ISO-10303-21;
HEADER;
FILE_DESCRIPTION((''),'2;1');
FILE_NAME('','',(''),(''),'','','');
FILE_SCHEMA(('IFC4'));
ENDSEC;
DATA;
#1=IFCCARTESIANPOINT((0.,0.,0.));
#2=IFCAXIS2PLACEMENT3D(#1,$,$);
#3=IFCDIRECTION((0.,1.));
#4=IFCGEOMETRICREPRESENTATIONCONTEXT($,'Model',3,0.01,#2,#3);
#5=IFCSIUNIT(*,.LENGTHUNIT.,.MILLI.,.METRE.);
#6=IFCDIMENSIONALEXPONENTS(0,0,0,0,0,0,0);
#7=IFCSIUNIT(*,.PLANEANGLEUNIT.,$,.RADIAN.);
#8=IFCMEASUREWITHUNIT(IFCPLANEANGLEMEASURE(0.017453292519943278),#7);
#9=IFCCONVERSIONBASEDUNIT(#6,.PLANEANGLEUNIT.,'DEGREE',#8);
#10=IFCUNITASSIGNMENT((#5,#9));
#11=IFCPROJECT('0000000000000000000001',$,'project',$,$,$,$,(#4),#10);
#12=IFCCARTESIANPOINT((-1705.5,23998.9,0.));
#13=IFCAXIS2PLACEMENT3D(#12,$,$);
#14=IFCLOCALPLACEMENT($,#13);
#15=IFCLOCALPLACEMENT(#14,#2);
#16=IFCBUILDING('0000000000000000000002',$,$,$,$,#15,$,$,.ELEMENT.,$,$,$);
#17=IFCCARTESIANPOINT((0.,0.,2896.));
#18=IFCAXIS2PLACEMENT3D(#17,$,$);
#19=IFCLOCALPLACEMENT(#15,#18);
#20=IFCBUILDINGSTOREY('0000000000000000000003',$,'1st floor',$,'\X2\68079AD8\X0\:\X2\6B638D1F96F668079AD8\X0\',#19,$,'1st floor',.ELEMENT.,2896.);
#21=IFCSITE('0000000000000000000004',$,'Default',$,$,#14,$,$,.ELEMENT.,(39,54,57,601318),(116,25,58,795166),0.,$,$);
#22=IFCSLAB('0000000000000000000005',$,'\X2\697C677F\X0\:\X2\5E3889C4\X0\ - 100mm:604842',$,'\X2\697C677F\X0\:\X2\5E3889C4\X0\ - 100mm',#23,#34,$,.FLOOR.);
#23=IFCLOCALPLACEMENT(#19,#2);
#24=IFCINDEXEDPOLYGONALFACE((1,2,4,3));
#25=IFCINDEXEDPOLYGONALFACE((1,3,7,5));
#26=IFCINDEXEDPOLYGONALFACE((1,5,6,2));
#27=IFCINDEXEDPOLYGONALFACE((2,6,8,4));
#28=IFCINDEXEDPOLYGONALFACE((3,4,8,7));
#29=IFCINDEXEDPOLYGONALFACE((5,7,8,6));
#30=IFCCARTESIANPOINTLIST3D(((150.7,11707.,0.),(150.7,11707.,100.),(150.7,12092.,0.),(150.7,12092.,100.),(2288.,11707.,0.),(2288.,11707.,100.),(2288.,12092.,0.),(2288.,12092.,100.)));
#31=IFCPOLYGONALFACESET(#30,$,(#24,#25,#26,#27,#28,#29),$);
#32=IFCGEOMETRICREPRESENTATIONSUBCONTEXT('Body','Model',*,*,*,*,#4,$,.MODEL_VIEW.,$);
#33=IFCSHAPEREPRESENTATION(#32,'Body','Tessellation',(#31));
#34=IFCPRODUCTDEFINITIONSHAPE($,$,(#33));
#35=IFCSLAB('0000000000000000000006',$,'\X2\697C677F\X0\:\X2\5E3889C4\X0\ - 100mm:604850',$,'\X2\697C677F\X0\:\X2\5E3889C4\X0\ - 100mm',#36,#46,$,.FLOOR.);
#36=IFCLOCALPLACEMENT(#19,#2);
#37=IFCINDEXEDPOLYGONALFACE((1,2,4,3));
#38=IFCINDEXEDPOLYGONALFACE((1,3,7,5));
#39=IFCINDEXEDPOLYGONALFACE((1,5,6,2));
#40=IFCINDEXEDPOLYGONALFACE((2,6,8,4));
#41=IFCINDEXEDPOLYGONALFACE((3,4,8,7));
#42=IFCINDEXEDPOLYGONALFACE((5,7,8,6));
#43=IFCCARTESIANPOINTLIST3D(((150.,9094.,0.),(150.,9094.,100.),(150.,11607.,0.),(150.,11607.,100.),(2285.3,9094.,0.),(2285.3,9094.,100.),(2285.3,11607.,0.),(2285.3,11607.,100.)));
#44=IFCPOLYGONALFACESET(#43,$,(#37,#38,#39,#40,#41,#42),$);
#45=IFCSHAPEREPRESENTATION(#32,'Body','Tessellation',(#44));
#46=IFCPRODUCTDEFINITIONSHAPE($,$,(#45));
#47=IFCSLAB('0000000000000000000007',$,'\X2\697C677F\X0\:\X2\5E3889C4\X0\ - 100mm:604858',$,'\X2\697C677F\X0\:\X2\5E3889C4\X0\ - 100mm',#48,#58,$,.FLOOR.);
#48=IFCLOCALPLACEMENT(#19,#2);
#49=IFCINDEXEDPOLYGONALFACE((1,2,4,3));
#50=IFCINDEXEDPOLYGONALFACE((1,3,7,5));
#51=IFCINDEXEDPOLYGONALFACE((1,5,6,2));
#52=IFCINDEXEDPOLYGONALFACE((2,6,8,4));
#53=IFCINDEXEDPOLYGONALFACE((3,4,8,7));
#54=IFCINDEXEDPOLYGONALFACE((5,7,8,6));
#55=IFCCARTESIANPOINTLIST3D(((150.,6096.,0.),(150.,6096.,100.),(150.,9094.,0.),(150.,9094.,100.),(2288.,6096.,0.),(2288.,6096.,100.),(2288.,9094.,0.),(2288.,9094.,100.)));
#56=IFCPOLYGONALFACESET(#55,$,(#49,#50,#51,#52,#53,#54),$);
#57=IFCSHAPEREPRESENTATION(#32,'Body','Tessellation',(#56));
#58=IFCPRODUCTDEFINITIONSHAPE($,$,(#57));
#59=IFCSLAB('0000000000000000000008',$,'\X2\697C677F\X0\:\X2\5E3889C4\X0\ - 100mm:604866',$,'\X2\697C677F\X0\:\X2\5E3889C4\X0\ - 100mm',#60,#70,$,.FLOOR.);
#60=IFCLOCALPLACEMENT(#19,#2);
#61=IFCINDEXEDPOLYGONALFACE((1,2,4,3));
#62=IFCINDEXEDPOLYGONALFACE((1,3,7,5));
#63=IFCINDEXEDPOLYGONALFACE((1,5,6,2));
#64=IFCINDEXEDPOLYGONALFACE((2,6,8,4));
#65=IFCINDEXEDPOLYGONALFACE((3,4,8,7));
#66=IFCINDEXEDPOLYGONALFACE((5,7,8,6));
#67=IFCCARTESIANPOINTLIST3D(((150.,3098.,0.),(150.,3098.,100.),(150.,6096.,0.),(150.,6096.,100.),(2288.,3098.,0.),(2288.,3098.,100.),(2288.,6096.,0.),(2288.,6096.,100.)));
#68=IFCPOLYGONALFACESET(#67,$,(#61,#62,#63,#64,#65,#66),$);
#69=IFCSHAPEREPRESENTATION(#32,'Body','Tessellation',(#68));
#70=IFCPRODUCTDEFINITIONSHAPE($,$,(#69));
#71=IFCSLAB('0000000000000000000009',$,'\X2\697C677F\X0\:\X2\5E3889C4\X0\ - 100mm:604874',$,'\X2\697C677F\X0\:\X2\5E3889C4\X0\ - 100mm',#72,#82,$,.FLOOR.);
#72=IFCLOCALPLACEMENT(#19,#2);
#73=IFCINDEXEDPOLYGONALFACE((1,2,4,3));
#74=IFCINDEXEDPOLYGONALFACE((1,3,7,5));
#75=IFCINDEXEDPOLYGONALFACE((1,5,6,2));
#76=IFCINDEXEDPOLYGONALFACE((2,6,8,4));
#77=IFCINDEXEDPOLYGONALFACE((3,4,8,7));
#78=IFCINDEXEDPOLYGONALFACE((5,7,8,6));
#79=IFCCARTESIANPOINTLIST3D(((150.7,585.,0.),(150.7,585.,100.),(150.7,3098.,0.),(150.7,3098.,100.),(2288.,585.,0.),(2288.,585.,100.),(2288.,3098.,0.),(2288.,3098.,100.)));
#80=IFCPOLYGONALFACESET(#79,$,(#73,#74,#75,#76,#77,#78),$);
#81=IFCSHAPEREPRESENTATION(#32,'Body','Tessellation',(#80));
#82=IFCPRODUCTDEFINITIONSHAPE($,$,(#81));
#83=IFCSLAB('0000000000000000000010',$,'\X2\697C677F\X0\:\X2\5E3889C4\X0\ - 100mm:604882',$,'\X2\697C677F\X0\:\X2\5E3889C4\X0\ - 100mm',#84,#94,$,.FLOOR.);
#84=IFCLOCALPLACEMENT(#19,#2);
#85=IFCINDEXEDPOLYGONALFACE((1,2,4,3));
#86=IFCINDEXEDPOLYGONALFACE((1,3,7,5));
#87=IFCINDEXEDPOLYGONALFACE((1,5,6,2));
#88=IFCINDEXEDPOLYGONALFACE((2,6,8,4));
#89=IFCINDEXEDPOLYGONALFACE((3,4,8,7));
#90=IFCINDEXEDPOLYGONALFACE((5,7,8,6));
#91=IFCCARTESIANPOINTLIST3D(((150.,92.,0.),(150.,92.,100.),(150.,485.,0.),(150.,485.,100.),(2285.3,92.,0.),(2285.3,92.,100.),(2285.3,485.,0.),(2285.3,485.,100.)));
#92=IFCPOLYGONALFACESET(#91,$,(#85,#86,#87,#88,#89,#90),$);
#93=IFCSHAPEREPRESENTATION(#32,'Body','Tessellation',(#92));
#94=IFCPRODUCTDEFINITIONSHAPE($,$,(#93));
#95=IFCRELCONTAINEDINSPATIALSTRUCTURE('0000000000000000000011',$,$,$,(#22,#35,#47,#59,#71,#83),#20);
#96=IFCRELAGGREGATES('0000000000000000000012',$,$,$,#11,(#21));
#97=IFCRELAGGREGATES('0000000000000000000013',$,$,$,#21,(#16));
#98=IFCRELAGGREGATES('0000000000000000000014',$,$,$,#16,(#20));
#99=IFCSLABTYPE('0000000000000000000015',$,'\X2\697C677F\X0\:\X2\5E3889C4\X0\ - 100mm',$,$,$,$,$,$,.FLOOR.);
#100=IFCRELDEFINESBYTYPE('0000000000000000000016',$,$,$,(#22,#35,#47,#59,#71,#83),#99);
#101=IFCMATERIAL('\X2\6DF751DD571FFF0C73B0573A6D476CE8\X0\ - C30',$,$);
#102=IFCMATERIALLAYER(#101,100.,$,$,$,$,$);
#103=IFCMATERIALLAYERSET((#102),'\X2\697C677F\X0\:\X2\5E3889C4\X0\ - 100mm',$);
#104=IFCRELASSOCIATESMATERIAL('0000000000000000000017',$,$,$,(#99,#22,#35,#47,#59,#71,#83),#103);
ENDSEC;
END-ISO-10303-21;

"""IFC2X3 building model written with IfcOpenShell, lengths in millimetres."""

from ifc_helpers import new_model, entity, si_unit, converted_unit, direction, frame, frame_2d, origin, origin_2d_with_axis, place, context, subcontext, project, spatial, rectangle, extrude, material, layer, layer_set, layer_usage, type_object, element, save


model = new_model("IFC2X3")

# Units and contexts
model_context = context("Model", 3, precision=0.01, world=origin(), true_north=direction((0.0, 1.0)))
body_context = subcontext(model_context, "Body", "Model", "MODEL_VIEW")
ifc_project = project(units=[si_unit("LENGTHUNIT", "METRE", prefix="MILLI"), converted_unit("PLANEANGLEUNIT", "DEGREE", entity("IfcPlaneAngleMeasure", 0.017453292519943278), si_unit("PLANEANGLEUNIT", "RADIAN"), dimensions=[0, 0, 0, 0, 0, 0, 0])], contexts=[model_context])

# Site, building, storey
site_placement = place(None, frame((-1705.5, 23998.9, 0.0)))
site = spatial("IfcSite", under=ifc_project, at=site_placement, Name="Default", CompositionType="ELEMENT", RefLatitude=(39, 54, 57, 601318), RefLongitude=(116, 25, 58, 795166), RefElevation=0.0)
building_placement = place(site_placement, origin())
building = spatial("IfcBuilding", under=site, at=building_placement, CompositionType="ELEMENT")
storey_placement = place(building_placement, frame((0.0, 0.0, 2896.0)))
storey = spatial("IfcBuildingStorey", under=building, at=storey_placement, Name="1st floor", ObjectType="标高:正负零标高", LongName="1st floor", CompositionType="ELEMENT", Elevation=2896.0)

# Slabs
ifc_material_1 = material(Name="混凝土，现场浇注 - C30")
ifc_layer_1 = layer(ifc_material_1, 100.0)
ifc_layer_set_1 = layer_set([ifc_layer_1], Name="楼板:常规 - 100mm")
ifc_layer_usage_1 = layer_usage(ifc_layer_set_1, "AXIS3", "POSITIVE", 0.0)
slab_type = type_object("IfcSlabType", Name="楼板:常规 - 100mm", PredefinedType="FLOOR", material=ifc_layer_set_1)
slab_1_placement = place(storey_placement, origin())
element("IfcSlab", 1, at=slab_1_placement, inside=storey, type_object=slab_type, material=ifc_layer_usage_1, Name="楼板:常规 - 100mm:604842", ObjectType="楼板:常规 - 100mm", PredefinedType="FLOOR", context=body_context, shape_type="SweptSolid", body=[
    extrude(rectangle(XDim=385.0, YDim=2137.3, at=origin_2d_with_axis()), frame((1219.3, 11899.5, 100.0), z_axis=(0.0, 0.0, -1.0), x_axis=(0.0, 1.0, 0.0)), (0.0, 0.0, 1.0), 100.0),
])
ifc_layer_usage_2 = layer_usage(ifc_layer_set_1, "AXIS3", "POSITIVE", 0.0)
slab_2_placement = place(storey_placement, origin())
element("IfcSlab", 2, at=slab_2_placement, inside=storey, type_object=slab_type, material=ifc_layer_usage_2, Name="楼板:常规 - 100mm:604850", ObjectType="楼板:常规 - 100mm", PredefinedType="FLOOR", context=body_context, shape_type="SweptSolid", body=[
    extrude(rectangle(XDim=2513.0, YDim=2135.3, at=frame_2d((0.0, 0.0), x_axis=(1.0, 0.0))), frame((1217.6, 10350.5, 100.0), z_axis=(0.0, 0.0, -1.0), x_axis=(0.0, 1.0, 0.0)), (0.0, 0.0, 1.0), 100.0),
])
ifc_layer_usage_3 = layer_usage(ifc_layer_set_1, "AXIS3", "POSITIVE", 0.0)
slab_3_placement = place(storey_placement, origin())
element("IfcSlab", 3, at=slab_3_placement, inside=storey, type_object=slab_type, material=ifc_layer_usage_3, Name="楼板:常规 - 100mm:604858", ObjectType="楼板:常规 - 100mm", PredefinedType="FLOOR", context=body_context, shape_type="SweptSolid", body=[
    extrude(rectangle(XDim=2998.0, YDim=2138.0, at=origin_2d_with_axis()), frame((1219.0, 7595.0, 100.0), z_axis=(0.0, 0.0, -1.0), x_axis=(0.0, 1.0, 0.0)), (0.0, 0.0, 1.0), 100.0),
])
ifc_layer_usage_4 = layer_usage(ifc_layer_set_1, "AXIS3", "POSITIVE", 0.0)
slab_4_placement = place(storey_placement, origin())
element("IfcSlab", 4, at=slab_4_placement, inside=storey, type_object=slab_type, material=ifc_layer_usage_4, Name="楼板:常规 - 100mm:604866", ObjectType="楼板:常规 - 100mm", PredefinedType="FLOOR", context=body_context, shape_type="SweptSolid", body=[
    extrude(rectangle(XDim=2998.0, YDim=2138.0, at=frame_2d((0.0, 0.0), x_axis=(1.0, 0.0))), frame((1219.0, 4597.0, 100.0), z_axis=(0.0, 0.0, -1.0), x_axis=(0.0, 1.0, 0.0)), (0.0, 0.0, 1.0), 100.0),
])
ifc_layer_usage_5 = layer_usage(ifc_layer_set_1, "AXIS3", "POSITIVE", 0.0)
slab_5_placement = place(storey_placement, origin())
element("IfcSlab", 5, at=slab_5_placement, inside=storey, type_object=slab_type, material=ifc_layer_usage_5, Name="楼板:常规 - 100mm:604874", ObjectType="楼板:常规 - 100mm", PredefinedType="FLOOR", context=body_context, shape_type="SweptSolid", body=[
    extrude(rectangle(XDim=2513.0, YDim=2137.3, at=origin_2d_with_axis()), frame((1219.3, 1841.5, 100.0), z_axis=(0.0, 0.0, -1.0), x_axis=(0.0, 1.0, 0.0)), (0.0, 0.0, 1.0), 100.0),
])
ifc_layer_usage_6 = layer_usage(ifc_layer_set_1, "AXIS3", "POSITIVE", 0.0)
slab_6_placement = place(storey_placement, origin())
element("IfcSlab", 6, at=slab_6_placement, inside=storey, type_object=slab_type, material=ifc_layer_usage_6, Name="楼板:常规 - 100mm:604882", ObjectType="楼板:常规 - 100mm", PredefinedType="FLOOR", context=body_context, shape_type="SweptSolid", body=[
    extrude(rectangle(XDim=393.0, YDim=2135.3, at=frame_2d((0.0, 0.0), x_axis=(1.0, 0.0))), frame((1217.7, 288.5, 100.0), z_axis=(0.0, 0.0, -1.0), x_axis=(0.0, 1.0, 0.0)), (0.0, 0.0, 1.0), 100.0),
])

save(model, "model.ifc")
